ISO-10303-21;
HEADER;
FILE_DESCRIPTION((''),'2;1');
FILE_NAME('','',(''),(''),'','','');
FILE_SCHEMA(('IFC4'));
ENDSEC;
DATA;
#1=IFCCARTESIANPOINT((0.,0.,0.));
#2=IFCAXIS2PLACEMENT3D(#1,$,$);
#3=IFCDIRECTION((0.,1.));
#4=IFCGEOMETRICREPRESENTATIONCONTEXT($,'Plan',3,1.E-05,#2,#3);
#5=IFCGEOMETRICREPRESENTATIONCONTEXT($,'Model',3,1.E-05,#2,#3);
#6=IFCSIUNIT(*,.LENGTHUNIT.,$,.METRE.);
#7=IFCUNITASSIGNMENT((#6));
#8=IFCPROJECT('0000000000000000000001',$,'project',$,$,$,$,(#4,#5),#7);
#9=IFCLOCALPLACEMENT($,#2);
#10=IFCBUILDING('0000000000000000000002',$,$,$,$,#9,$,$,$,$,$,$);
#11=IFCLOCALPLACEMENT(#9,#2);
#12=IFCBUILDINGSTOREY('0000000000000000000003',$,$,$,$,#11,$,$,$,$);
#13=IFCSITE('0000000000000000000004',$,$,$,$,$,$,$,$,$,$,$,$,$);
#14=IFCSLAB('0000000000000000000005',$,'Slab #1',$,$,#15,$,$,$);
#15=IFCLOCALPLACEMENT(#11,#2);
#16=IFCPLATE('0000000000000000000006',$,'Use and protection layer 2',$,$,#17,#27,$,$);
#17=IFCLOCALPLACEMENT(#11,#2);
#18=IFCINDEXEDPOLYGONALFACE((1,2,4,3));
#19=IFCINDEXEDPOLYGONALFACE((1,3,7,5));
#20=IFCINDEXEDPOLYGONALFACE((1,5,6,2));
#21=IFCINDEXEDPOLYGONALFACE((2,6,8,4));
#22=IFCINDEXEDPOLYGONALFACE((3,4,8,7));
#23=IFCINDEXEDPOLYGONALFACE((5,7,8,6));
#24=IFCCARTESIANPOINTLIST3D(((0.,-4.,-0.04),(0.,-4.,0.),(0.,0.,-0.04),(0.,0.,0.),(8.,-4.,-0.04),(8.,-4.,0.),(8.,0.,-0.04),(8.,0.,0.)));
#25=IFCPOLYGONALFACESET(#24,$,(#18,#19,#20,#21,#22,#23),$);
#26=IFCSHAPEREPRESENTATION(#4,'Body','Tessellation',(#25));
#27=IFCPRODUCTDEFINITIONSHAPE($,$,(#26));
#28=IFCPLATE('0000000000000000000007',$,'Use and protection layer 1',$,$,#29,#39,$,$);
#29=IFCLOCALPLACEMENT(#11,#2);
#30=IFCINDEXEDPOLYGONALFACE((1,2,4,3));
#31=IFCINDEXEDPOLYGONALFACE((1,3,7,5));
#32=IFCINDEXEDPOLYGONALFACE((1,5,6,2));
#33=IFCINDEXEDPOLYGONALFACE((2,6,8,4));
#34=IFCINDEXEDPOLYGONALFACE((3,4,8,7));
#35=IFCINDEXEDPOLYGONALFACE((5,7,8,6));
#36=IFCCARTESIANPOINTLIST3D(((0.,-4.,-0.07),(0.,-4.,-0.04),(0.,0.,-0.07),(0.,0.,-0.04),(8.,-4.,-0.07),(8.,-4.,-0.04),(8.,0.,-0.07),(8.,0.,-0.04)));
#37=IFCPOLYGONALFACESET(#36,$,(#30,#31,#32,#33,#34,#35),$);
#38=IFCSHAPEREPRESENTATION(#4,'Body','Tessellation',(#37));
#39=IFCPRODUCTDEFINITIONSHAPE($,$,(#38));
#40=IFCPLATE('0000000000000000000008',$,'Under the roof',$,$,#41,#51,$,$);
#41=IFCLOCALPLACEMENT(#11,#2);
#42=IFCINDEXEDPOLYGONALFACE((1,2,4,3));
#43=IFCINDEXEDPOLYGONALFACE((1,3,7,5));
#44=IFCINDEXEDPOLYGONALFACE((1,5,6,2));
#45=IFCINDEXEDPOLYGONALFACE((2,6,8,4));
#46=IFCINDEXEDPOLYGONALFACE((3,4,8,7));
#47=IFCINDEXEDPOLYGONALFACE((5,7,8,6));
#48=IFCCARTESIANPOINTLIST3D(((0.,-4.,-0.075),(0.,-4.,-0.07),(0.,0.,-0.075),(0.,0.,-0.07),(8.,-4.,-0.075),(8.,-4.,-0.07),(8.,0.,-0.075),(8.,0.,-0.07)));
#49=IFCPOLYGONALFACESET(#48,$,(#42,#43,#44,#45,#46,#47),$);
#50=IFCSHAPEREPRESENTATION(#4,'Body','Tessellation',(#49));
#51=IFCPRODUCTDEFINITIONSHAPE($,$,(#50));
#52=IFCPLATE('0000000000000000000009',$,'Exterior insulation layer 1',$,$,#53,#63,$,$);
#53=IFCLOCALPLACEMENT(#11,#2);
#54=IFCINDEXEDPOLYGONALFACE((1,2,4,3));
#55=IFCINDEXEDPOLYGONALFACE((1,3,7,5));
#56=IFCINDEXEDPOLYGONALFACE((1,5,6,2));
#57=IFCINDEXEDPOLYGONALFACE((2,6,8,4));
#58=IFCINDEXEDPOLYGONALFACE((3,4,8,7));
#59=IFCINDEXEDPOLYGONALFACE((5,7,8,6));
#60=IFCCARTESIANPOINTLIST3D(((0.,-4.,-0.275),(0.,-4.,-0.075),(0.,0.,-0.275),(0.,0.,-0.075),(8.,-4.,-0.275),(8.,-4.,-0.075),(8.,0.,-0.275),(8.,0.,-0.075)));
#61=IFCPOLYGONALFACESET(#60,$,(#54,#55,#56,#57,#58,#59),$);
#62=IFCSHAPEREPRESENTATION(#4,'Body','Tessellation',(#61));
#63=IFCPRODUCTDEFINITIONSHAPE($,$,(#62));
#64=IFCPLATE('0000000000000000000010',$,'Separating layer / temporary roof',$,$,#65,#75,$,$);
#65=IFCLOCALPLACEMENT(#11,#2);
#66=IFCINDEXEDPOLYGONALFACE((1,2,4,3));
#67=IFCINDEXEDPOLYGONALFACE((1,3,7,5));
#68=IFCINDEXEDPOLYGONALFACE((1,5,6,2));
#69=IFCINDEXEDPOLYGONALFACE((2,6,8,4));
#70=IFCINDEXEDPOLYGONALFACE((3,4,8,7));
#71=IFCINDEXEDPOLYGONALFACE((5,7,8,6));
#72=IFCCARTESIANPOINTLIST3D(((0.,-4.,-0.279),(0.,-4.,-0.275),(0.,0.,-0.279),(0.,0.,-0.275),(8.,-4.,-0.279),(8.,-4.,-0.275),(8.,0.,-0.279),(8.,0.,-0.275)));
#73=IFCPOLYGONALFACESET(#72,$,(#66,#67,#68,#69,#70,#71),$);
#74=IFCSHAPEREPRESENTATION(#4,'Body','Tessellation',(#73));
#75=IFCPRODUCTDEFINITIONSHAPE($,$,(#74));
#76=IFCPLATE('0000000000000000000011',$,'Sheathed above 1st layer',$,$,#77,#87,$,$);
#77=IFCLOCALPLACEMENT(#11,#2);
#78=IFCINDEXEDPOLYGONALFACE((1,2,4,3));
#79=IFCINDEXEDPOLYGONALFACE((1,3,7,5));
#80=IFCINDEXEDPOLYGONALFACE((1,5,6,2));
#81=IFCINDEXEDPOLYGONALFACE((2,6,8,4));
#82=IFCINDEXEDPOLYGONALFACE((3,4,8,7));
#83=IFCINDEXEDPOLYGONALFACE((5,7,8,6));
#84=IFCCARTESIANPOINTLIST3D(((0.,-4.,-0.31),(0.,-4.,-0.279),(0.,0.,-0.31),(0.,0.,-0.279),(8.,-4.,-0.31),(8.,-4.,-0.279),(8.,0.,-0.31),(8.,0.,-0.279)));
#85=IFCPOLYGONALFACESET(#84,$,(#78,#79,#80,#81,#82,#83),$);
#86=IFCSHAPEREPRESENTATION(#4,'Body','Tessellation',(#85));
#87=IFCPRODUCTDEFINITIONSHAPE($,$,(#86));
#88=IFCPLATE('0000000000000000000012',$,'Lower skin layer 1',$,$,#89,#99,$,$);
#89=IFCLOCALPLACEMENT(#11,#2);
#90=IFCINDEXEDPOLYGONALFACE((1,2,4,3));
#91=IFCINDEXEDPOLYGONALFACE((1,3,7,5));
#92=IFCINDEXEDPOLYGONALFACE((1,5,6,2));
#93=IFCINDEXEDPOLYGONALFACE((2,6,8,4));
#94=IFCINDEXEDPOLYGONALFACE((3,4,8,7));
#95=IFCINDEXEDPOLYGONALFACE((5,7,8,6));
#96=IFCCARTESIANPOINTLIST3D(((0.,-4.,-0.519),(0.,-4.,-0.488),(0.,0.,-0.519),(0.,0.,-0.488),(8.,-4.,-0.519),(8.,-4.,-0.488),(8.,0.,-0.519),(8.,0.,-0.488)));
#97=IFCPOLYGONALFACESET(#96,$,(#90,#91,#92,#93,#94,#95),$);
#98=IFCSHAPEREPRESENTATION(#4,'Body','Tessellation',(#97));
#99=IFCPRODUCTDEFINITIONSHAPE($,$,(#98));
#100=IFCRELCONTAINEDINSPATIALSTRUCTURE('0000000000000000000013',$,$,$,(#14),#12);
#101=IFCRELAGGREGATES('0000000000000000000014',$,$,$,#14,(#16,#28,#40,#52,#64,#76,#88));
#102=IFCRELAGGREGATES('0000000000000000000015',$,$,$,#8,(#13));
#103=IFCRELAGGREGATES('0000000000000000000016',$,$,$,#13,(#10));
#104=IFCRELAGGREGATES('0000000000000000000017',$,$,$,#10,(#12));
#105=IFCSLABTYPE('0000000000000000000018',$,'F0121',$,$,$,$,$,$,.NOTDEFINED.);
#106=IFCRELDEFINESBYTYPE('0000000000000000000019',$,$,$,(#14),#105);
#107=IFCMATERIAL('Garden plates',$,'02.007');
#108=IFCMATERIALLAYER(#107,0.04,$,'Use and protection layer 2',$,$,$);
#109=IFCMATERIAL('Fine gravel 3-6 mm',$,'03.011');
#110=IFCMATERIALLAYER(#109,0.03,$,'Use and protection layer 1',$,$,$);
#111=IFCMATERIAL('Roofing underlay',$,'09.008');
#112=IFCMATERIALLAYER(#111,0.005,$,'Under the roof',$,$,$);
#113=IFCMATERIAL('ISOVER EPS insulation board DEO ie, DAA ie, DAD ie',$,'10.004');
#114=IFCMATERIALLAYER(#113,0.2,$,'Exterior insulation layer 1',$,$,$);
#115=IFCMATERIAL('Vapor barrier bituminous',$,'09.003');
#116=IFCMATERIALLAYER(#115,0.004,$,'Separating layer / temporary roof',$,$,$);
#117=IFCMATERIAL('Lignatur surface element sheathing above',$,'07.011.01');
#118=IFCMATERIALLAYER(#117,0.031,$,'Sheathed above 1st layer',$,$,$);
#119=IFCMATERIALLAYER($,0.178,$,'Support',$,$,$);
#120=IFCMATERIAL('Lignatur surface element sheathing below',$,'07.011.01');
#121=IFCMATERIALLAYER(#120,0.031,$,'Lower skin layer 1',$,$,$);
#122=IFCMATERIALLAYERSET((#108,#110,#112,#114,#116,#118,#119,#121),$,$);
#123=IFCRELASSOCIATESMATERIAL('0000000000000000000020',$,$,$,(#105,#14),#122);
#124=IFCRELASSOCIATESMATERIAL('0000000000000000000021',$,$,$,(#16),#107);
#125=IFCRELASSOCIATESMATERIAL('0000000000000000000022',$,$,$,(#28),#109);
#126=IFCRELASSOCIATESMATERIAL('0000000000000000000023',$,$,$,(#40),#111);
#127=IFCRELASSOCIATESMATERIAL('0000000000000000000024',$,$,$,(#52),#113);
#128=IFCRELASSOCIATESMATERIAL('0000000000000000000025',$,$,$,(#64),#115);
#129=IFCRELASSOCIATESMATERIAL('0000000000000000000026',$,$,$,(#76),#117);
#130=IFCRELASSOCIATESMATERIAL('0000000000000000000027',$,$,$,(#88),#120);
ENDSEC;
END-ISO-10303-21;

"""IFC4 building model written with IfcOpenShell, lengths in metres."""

from ifc_helpers import new_model, si_unit, direction, frame, frame_2d, origin, origin_with_axes, place, context, project, spatial, rectangle, extrude, material, layer, layer_set, type_object, element, aggregate, save


model = new_model("IFC4")

# Units and contexts
plan_context = context("Plan", 3, precision=1e-05, world=origin(), true_north=direction((0.0, 1.0)))
model_context = context("Model", 3, precision=1e-05, world=origin(), true_north=direction((0.0, 1.0)))
ifc_project = project(units=[si_unit("LENGTHUNIT", "METRE")], contexts=[plan_context, model_context])

# Site, building, storey
site = spatial("IfcSite", under=ifc_project)
building_placement = place(None, origin())
building = spatial("IfcBuilding", under=site, at=building_placement)
storey_placement = place(building_placement, origin())
storey = spatial("IfcBuildingStorey", under=building, at=storey_placement)

# Slab, plates
ifc_material_1 = material(Name="Garden plates", Category="02.007")
ifc_layer_1 = layer(ifc_material_1, 0.04, Name="Use and protection layer 2")
ifc_material_2 = material(Name="Fine gravel 3-6 mm", Category="03.011")
ifc_layer_2 = layer(ifc_material_2, 0.03, Name="Use and protection layer 1")
ifc_material_3 = material(Name="Roofing underlay", Category="09.008")
ifc_layer_3 = layer(ifc_material_3, 0.005, Name="Under the roof")
ifc_material_4 = material(Name="ISOVER EPS insulation board DEO ie, DAA ie, DAD ie", Category="10.004")
ifc_layer_4 = layer(ifc_material_4, 0.2, Name="Exterior insulation layer 1")
ifc_material_5 = material(Name="Vapor barrier bituminous", Category="09.003")
ifc_layer_5 = layer(ifc_material_5, 0.004, Name="Separating layer / temporary roof")
ifc_material_6 = material(Name="Lignatur surface element sheathing above", Category="07.011.01")
ifc_layer_6 = layer(ifc_material_6, 0.031, Name="Sheathed above 1st layer")
ifc_layer_7 = layer(None, 0.178, Name="Support")
ifc_material_7 = material(Name="Lignatur surface element sheathing below", Category="07.011.01")
ifc_layer_8 = layer(ifc_material_7, 0.031, Name="Lower skin layer 1")
ifc_layer_set = layer_set([ifc_layer_1, ifc_layer_2, ifc_layer_3, ifc_layer_4, ifc_layer_5, ifc_layer_6, ifc_layer_7, ifc_layer_8])
slab_type = type_object("IfcSlabType", Name="F0121", PredefinedType="NOTDEFINED", material=ifc_layer_set)
slab_placement = place(None, frame((0.0, 0.0, 0.0), z_axis=(0.0, 0.0, -1.0), x_axis=(1.0, 0.0, 0.0)))
slab = element("IfcSlab", 1, at=slab_placement, inside=storey, type_object=slab_type, material=ifc_layer_set, Name="Slab #1")
plate_1_placement = place(slab_placement, origin())
plate_1 = element("IfcPlate", 2, at=plate_1_placement, material=ifc_material_1, Name="Use and protection layer 2", context=plan_context, shape_type="SweptSolid", body=[
    extrude(rectangle(XDim=8.0, YDim=4.0, at=frame_2d((4.0, 2.0), x_axis=(1.0, 0.0))), origin_with_axes(), (0.0, 0.0, 1.0), 0.04),
])
plate_2_placement = place(slab_placement, origin())
plate_2 = element("IfcPlate", 3, at=plate_2_placement, material=ifc_material_2, Name="Use and protection layer 1", context=plan_context, shape_type="SweptSolid", body=[
    extrude(rectangle(XDim=8.0, YDim=4.0, at=frame_2d((4.0, 2.0), x_axis=(1.0, 0.0))), frame((0.0, 0.0, 0.04), z_axis=(0.0, 0.0, 1.0), x_axis=(1.0, 0.0, 0.0)), (0.0, 0.0, 1.0), 0.03),
])
plate_3_placement = place(slab_placement, origin())
plate_3 = element("IfcPlate", 4, at=plate_3_placement, material=ifc_material_3, Name="Under the roof", context=plan_context, shape_type="SweptSolid", body=[
    extrude(rectangle(XDim=8.0, YDim=4.0, at=frame_2d((4.0, 2.0), x_axis=(1.0, 0.0))), frame((0.0, 0.0, 0.07), z_axis=(0.0, 0.0, 1.0), x_axis=(1.0, 0.0, 0.0)), (0.0, 0.0, 1.0), 0.005),
])
plate_4_placement = place(slab_placement, origin())
plate_4 = element("IfcPlate", 5, at=plate_4_placement, material=ifc_material_4, Name="Exterior insulation layer 1", context=plan_context, shape_type="SweptSolid", body=[
    extrude(rectangle(XDim=8.0, YDim=4.0, at=frame_2d((4.0, 2.0), x_axis=(1.0, 0.0))), frame((0.0, 0.0, 0.075), z_axis=(0.0, 0.0, 1.0), x_axis=(1.0, 0.0, 0.0)), (0.0, 0.0, 1.0), 0.2),
])
plate_5_placement = place(slab_placement, origin())
plate_5 = element("IfcPlate", 6, at=plate_5_placement, material=ifc_material_5, Name="Separating layer / temporary roof", context=plan_context, shape_type="SweptSolid", body=[
    extrude(rectangle(XDim=8.0, YDim=4.0, at=frame_2d((4.0, 2.0), x_axis=(1.0, 0.0))), frame((0.0, 0.0, 0.275), z_axis=(0.0, 0.0, 1.0), x_axis=(1.0, 0.0, 0.0)), (0.0, 0.0, 1.0), 0.004),
])
plate_6_placement = place(slab_placement, origin())
plate_6 = element("IfcPlate", 7, at=plate_6_placement, material=ifc_material_6, Name="Sheathed above 1st layer", context=plan_context, shape_type="SweptSolid", body=[
    extrude(rectangle(XDim=8.0, YDim=4.0, at=frame_2d((4.0, 2.0), x_axis=(1.0, 0.0))), frame((0.0, 0.0, 0.279), z_axis=(0.0, 0.0, 1.0), x_axis=(1.0, 0.0, 0.0)), (0.0, 0.0, 1.0), 0.031),
])
plate_7_placement = place(slab_placement, origin())
plate_7 = element("IfcPlate", 8, at=plate_7_placement, material=ifc_material_7, Name="Lower skin layer 1", context=plan_context, shape_type="SweptSolid", body=[
    extrude(rectangle(XDim=8.0, YDim=4.0, at=frame_2d((4.0, 2.0), x_axis=(1.0, 0.0))), frame((0.0, 0.0, 0.488), z_axis=(0.0, 0.0, 1.0), x_axis=(1.0, 0.0, 0.0)), (0.0, 0.0, 1.0), 0.031),
])
aggregate(slab, [plate_1, plate_2, plate_3, plate_4, plate_5, plate_6, plate_7])

save(model, "model.ifc")
